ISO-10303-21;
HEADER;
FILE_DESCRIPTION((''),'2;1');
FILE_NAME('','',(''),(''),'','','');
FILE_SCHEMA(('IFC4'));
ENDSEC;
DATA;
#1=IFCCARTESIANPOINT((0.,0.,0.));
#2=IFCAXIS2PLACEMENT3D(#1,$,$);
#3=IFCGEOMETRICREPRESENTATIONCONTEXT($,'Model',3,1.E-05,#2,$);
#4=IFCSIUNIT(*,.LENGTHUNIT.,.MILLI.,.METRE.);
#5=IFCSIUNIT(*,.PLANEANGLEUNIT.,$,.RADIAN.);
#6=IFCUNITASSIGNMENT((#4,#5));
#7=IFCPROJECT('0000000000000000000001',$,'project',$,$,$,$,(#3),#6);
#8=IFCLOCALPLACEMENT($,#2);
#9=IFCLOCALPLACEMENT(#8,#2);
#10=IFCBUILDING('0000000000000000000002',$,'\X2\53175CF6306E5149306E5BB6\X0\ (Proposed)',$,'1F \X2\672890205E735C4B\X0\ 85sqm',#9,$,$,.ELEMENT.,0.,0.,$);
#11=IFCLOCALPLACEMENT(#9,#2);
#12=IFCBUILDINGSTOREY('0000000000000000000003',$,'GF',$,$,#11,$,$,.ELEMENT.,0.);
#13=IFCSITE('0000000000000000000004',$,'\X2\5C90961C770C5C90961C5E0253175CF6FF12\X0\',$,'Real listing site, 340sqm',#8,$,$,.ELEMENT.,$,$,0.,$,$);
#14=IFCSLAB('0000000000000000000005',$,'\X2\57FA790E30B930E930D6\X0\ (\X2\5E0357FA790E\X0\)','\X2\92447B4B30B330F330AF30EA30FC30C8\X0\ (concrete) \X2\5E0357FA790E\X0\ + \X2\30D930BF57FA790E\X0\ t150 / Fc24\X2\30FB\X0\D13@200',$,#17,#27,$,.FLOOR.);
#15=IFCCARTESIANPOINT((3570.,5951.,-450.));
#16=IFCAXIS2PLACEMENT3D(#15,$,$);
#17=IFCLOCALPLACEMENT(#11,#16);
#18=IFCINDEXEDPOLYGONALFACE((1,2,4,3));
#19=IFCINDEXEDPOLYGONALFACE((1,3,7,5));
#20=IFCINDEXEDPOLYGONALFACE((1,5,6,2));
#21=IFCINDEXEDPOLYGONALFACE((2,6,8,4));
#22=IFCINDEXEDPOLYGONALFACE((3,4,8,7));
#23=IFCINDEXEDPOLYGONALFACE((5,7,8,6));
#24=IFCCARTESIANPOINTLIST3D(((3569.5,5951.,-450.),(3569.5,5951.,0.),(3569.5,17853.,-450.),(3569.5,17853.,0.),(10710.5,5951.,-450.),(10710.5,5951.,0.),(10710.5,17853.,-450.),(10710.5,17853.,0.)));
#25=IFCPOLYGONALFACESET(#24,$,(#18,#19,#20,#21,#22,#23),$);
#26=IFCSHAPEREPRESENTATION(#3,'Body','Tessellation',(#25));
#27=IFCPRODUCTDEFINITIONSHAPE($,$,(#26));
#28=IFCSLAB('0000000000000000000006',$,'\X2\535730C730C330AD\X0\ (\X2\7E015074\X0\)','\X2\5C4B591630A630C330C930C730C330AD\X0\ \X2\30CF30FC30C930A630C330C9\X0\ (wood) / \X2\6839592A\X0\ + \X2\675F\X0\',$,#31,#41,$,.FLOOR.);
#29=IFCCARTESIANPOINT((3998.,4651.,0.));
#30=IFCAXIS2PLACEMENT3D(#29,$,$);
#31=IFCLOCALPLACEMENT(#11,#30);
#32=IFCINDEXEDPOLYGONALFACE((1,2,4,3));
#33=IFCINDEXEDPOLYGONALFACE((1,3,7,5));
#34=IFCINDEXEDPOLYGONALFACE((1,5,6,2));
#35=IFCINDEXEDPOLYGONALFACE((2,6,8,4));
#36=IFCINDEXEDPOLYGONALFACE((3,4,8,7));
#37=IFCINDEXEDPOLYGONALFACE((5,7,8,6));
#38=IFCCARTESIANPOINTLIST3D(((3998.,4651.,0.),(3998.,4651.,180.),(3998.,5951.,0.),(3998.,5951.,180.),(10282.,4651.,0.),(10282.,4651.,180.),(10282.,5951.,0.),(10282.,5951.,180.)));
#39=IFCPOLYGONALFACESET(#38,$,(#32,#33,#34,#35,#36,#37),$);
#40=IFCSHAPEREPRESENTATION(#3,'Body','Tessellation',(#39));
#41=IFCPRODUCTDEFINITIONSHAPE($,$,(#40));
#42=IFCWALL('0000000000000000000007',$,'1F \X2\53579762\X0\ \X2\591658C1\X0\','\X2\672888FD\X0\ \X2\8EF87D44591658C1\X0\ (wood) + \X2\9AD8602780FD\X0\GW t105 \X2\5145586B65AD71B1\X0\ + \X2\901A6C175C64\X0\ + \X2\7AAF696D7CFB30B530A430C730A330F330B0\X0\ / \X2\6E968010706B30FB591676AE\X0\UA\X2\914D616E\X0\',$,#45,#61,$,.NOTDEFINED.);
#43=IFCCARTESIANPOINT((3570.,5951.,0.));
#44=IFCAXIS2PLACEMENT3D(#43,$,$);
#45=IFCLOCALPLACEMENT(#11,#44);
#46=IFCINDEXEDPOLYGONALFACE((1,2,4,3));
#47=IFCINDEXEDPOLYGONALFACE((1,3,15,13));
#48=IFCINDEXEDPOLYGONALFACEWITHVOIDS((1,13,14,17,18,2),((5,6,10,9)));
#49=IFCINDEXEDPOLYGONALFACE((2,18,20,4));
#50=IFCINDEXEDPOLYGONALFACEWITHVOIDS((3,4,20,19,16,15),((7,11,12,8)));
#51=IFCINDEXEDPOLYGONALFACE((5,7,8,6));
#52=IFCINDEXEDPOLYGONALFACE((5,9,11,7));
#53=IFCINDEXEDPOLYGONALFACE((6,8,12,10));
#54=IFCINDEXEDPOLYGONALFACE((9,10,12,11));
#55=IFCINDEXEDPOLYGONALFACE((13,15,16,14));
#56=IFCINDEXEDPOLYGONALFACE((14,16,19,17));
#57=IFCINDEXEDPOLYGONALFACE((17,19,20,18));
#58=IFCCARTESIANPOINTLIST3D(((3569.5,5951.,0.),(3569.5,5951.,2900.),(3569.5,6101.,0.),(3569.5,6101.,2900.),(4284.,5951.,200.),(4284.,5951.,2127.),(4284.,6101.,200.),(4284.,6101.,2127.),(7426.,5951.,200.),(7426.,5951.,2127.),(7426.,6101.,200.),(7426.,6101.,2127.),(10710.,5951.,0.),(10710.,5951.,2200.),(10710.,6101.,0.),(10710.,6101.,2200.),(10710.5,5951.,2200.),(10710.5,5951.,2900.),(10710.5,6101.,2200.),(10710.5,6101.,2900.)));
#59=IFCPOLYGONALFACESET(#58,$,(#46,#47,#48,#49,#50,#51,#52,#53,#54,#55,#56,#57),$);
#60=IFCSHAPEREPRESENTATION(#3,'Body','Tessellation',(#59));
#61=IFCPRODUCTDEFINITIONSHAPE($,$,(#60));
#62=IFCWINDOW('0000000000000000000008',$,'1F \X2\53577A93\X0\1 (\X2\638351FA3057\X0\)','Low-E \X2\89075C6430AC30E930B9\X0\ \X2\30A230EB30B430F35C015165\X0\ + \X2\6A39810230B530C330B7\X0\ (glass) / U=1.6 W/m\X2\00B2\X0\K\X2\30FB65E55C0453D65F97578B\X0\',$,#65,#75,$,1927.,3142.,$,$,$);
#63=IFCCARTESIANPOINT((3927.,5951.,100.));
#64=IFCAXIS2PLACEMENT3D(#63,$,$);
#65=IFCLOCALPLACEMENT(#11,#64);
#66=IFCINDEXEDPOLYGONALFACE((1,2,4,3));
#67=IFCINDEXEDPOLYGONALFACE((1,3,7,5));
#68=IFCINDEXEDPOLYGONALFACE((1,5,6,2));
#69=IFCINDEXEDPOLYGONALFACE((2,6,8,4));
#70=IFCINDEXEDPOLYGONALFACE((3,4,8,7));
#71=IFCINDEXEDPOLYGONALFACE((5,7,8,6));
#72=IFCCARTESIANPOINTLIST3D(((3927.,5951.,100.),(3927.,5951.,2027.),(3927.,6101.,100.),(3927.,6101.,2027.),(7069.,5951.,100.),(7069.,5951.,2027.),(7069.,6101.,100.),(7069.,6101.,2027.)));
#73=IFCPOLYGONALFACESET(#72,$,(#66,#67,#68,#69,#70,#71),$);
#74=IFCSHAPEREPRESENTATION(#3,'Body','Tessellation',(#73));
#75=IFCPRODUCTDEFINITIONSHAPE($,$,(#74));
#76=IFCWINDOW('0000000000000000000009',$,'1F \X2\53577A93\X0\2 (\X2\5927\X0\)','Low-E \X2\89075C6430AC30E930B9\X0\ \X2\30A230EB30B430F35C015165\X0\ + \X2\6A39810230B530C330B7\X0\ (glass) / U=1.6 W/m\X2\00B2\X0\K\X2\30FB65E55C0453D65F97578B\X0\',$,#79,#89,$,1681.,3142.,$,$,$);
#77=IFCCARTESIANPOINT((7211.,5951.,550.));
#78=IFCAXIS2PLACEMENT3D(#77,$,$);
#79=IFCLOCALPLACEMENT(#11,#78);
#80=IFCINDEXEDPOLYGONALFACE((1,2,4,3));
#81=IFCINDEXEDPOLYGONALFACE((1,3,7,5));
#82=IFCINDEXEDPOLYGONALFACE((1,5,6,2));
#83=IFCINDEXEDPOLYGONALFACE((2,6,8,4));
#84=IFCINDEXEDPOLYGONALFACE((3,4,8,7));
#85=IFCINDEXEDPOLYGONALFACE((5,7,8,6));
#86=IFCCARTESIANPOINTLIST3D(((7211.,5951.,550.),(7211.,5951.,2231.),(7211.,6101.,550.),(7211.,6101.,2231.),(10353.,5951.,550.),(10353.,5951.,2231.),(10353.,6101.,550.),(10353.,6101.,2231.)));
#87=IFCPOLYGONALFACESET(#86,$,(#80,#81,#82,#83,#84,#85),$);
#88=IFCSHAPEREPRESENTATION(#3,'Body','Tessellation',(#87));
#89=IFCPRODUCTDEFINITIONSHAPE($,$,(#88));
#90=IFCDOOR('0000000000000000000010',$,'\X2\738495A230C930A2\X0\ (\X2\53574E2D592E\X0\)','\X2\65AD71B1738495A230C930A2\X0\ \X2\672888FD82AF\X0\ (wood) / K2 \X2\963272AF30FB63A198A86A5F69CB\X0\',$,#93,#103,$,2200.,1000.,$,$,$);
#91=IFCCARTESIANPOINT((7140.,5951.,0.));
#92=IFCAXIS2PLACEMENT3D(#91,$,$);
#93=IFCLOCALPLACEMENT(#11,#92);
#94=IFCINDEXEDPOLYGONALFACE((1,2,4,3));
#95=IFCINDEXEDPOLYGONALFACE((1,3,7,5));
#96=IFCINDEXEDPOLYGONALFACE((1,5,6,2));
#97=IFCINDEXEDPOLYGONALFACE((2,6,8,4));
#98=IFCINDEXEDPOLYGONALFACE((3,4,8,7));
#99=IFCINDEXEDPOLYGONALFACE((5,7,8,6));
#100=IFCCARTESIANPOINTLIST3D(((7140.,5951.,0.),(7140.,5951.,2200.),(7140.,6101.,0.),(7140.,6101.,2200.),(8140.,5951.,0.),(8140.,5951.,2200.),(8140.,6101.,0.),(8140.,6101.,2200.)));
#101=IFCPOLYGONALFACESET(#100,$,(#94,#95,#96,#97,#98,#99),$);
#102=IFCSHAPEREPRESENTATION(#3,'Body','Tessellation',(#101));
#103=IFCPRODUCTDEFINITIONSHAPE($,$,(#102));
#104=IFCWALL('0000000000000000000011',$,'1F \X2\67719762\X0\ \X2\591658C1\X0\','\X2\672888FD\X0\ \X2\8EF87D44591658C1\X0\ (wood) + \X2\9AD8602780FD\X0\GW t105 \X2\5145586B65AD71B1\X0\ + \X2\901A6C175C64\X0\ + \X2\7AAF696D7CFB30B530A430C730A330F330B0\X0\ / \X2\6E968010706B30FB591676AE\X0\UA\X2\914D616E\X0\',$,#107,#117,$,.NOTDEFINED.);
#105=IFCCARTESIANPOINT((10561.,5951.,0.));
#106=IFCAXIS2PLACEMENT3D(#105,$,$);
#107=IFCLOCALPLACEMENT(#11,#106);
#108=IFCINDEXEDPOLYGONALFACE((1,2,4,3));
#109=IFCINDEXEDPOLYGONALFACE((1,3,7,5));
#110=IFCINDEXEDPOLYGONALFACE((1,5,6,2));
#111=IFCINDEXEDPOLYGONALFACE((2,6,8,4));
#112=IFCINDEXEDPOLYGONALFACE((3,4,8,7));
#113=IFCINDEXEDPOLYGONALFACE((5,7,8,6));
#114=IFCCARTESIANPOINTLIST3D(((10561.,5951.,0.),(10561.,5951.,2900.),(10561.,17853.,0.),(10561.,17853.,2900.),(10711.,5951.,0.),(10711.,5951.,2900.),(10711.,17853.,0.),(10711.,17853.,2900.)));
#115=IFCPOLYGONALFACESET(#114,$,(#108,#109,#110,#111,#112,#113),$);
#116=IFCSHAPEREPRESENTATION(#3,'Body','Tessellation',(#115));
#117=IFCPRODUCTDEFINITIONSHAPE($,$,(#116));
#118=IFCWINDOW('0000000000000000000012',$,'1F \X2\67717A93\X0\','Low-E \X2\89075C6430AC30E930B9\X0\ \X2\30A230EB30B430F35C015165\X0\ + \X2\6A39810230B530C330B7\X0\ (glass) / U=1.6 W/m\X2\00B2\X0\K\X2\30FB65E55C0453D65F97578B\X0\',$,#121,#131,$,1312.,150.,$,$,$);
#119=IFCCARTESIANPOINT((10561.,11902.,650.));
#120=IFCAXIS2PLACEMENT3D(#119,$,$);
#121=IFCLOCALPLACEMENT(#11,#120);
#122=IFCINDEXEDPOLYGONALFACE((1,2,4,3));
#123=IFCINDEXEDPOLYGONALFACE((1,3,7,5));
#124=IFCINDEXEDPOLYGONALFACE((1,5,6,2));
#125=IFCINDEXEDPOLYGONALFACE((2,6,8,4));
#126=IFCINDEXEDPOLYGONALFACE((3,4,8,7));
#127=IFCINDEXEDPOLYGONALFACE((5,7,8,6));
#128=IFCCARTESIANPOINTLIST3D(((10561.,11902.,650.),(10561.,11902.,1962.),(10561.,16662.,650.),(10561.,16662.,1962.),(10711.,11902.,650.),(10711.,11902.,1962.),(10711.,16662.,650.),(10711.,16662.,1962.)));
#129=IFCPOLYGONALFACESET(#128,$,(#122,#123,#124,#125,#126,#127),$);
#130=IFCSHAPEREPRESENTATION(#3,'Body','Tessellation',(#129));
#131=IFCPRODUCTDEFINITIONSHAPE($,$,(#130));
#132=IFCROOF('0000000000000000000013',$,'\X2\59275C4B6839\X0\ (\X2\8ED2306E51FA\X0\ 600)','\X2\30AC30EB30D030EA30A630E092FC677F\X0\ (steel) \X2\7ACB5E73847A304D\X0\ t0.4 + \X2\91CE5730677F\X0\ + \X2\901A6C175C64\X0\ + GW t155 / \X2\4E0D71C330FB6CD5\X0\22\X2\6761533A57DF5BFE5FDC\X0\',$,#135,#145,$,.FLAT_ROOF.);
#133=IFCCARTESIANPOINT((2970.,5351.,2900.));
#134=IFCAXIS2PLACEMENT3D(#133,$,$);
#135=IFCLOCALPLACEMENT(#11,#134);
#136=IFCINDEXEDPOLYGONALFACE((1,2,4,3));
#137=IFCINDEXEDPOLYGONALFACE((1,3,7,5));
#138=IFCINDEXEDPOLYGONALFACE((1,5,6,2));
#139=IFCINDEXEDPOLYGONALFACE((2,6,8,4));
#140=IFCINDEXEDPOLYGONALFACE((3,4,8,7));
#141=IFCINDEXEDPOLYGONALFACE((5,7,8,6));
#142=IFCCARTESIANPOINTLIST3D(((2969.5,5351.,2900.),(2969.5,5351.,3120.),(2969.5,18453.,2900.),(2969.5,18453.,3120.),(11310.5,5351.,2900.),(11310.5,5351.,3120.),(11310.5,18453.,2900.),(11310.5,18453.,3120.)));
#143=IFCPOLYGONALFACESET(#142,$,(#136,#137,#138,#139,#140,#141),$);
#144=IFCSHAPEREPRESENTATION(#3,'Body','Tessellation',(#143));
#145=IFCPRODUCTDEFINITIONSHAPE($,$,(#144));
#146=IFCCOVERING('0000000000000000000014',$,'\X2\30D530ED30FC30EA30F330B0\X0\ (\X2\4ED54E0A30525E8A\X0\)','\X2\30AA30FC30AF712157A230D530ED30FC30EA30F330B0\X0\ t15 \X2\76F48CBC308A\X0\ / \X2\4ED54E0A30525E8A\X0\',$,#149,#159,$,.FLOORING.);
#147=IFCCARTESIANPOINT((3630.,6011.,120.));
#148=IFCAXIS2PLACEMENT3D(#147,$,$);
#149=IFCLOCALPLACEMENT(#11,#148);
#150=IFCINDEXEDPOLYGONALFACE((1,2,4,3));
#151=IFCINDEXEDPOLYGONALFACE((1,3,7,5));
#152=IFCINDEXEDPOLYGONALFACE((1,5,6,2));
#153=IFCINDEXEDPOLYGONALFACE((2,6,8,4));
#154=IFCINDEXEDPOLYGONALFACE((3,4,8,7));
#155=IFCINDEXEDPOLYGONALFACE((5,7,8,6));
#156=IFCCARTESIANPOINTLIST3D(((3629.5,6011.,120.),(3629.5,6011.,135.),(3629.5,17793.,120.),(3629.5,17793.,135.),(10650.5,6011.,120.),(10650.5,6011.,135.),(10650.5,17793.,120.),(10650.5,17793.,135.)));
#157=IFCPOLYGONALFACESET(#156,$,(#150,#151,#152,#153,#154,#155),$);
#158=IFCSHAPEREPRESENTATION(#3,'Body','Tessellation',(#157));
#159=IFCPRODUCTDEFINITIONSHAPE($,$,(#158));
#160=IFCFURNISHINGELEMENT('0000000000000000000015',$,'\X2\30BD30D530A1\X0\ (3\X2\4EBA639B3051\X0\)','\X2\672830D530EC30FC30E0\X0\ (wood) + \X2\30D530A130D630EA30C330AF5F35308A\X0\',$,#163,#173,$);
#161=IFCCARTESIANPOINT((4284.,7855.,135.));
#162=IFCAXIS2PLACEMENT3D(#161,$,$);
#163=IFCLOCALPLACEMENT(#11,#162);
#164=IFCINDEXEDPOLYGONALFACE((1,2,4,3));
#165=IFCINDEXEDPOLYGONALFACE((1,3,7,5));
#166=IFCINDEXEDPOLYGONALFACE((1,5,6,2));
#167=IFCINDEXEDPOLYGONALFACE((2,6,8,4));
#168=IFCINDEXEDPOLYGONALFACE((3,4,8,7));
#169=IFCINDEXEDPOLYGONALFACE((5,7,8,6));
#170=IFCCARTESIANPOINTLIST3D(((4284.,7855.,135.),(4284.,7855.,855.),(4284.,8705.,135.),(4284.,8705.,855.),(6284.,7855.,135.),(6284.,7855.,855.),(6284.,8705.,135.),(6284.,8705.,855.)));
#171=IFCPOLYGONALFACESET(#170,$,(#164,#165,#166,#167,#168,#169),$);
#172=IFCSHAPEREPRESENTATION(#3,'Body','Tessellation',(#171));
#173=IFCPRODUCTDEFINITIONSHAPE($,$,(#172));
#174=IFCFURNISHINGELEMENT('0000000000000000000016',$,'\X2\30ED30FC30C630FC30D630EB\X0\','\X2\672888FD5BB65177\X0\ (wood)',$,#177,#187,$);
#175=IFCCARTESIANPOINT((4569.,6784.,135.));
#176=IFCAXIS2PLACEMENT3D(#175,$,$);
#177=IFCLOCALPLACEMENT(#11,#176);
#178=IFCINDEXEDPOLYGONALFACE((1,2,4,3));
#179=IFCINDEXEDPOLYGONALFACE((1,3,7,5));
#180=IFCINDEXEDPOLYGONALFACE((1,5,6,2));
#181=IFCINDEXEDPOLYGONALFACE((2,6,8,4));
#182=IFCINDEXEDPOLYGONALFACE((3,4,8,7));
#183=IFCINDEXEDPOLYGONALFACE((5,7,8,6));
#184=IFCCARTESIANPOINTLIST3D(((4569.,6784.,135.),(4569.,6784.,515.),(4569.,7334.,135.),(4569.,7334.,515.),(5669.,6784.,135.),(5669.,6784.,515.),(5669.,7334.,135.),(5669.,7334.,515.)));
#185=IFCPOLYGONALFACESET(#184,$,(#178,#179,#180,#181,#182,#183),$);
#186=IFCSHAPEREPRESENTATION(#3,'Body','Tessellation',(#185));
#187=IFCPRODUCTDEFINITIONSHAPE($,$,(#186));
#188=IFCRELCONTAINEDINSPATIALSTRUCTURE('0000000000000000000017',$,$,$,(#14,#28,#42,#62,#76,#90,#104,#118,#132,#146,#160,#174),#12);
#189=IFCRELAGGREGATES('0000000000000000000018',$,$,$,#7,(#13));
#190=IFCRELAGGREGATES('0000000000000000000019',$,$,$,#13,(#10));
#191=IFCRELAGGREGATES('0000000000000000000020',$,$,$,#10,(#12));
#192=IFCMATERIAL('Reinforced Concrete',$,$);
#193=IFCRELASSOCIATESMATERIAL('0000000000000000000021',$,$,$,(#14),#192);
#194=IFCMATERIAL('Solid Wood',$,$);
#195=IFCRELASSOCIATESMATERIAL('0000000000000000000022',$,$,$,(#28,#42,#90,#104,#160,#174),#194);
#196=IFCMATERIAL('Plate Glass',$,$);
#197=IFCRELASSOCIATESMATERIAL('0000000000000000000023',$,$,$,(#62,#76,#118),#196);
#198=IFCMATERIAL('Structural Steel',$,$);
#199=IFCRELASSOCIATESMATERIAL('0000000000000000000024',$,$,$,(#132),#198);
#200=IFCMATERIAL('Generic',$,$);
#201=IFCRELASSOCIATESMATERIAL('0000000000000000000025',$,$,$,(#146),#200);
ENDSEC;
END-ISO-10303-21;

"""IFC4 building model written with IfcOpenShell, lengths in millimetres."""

from ifc_helpers import new_model, si_unit, frame, frame_2d, origin, place, context, project, spatial, rectangle, extrude, material, element, fill, save


model = new_model("IFC4")

# Units and contexts
model_context = context("Model", 3, precision=1e-05, world=origin())
ifc_project = project(units=[si_unit("LENGTHUNIT", "METRE", prefix="MILLI"), si_unit("PLANEANGLEUNIT", "RADIAN")], contexts=[model_context])

# Site, building, storey
site_placement = place(None, origin())
site = spatial("IfcSite", under=ifc_project, at=site_placement, Name="岐阜県岐阜市北島２", ObjectType="Real listing site, 340sqm", CompositionType="ELEMENT", RefElevation=0.0)
building_placement = place(site_placement, origin())
building = spatial("IfcBuilding", under=site, at=building_placement, Name="北島の光の家 (Proposed)", ObjectType="1F 木造平屋 85sqm", CompositionType="ELEMENT", ElevationOfRefHeight=0.0, ElevationOfTerrain=0.0)
storey_placement = place(building_placement, origin())
storey = spatial("IfcBuildingStorey", under=building, at=storey_placement, Name="GF", CompositionType="ELEMENT", Elevation=0.0)

# Slabs
ifc_material_1 = material(Name="Reinforced Concrete")
slab_1_placement = place(storey_placement, frame((3570.0, 5951.0, -450.0)))
element("IfcSlab", 1, at=slab_1_placement, inside=storey, material=ifc_material_1, Name="基礎スラブ (布基礎)", Description="鉄筋コンクリート (concrete) 布基礎 + ベタ基礎 t150 / Fc24・D13@200", PredefinedType="FLOOR", context=model_context, shape_type="SweptSolid", body=[
    extrude(rectangle(XDim=7141.0, YDim=11902.0, at=frame_2d((3570.0, 5951.0))), frame((3570.0, 5951.0, -450.0)), (0.0, 0.0, 1.0), 450.0),
])
ifc_material_2 = material(Name="Solid Wood")
slab_2_placement = place(storey_placement, frame((3998.0, 4651.0, 0.0)))
element("IfcSlab", 2, at=slab_2_placement, inside=storey, material=ifc_material_2, Name="南デッキ (縁側)", Description="屋外ウッドデッキ ハードウッド (wood) / 根太 + 束", PredefinedType="FLOOR", context=model_context, shape_type="SweptSolid", body=[
    extrude(rectangle(XDim=6284.0, YDim=1300.0, at=frame_2d((3142.0, 650.0))), frame((3998.0, 4651.0, 0.0)), (0.0, 0.0, 1.0), 180.0),
])

# Wall, openings, windows, door
wall_1_placement = place(storey_placement, frame((3570.0, 5951.0, 0.0)))
wall_1 = element("IfcWall", 3, at=wall_1_placement, inside=storey, material=ifc_material_2, Name="1F 南面 外壁", Description="木製 軸組外壁 (wood) + 高性能GW t105 充填断熱 + 通気層 + 窯業系サイディング / 準耐火・外皮UA配慮", PredefinedType="NOTDEFINED", context=model_context, shape_type="SweptSolid", body=[
    extrude(rectangle(XDim=7141.0, YDim=150.0, at=frame_2d((3570.0, 75.0))), frame((3570.0, 5951.0, 0.0)), (0.0, 0.0, 1.0), 2900.0),
])
opening_1_placement = place(storey_placement, frame((3927.0, 5951.0, 100.0)))
opening_1 = element("IfcOpeningElement", 4, at=opening_1_placement, cuts=wall_1, PredefinedType="NOTDEFINED", context=model_context, shape_type="SweptSolid", body=[
    extrude(rectangle(XDim=3142.0, YDim=150.0, at=frame_2d((1571.0, 75.0))), frame((3927.0, 5951.0, 100.0)), (0.0, 0.0, 1.0), 1927.0),
])
opening_2_placement = place(storey_placement, frame((7211.0, 5951.0, 550.0)))
opening_2 = element("IfcOpeningElement", 5, at=opening_2_placement, cuts=wall_1, PredefinedType="NOTDEFINED", context=model_context, shape_type="SweptSolid", body=[
    extrude(rectangle(XDim=3142.0, YDim=150.0, at=frame_2d((1571.0, 75.0))), frame((7211.0, 5951.0, 550.0)), (0.0, 0.0, 1.0), 1681.0),
])
opening_3_placement = place(storey_placement, frame((7140.0, 5951.0, 0.0)))
opening_3 = element("IfcOpeningElement", 6, at=opening_3_placement, cuts=wall_1, PredefinedType="NOTDEFINED", context=model_context, shape_type="SweptSolid", body=[
    extrude(rectangle(XDim=1000.0, YDim=150.0, at=frame_2d((500.0, 75.0))), frame((7140.0, 5951.0, 0.0)), (0.0, 0.0, 1.0), 2200.0),
])
ifc_material_3 = material(Name="Plate Glass")
window_1_placement = place(storey_placement, frame((3927.0, 5951.0, 100.0)))
window_1 = element("IfcWindow", 7, at=window_1_placement, inside=storey, material=ifc_material_3, Name="1F 南窓1 (掃出し)", Description="Low-E 複層ガラス アルゴン封入 + 樹脂サッシ (glass) / U=1.6 W/m²K・日射取得型", OverallHeight=1927.0, OverallWidth=3142.0, context=model_context, shape_type="SweptSolid", body=[
    extrude(rectangle(XDim=3142.0, YDim=150.0, at=frame_2d((1571.0, 75.0))), frame((3927.0, 5951.0, 100.0)), (0.0, 0.0, 1.0), 1927.0),
])
fill(opening_1, window_1)
window_2_placement = place(storey_placement, frame((7211.0, 5951.0, 550.0)))
window_2 = element("IfcWindow", 8, at=window_2_placement, inside=storey, material=ifc_material_3, Name="1F 南窓2 (大)", Description="Low-E 複層ガラス アルゴン封入 + 樹脂サッシ (glass) / U=1.6 W/m²K・日射取得型", OverallHeight=1681.0, OverallWidth=3142.0, context=model_context, shape_type="SweptSolid", body=[
    extrude(rectangle(XDim=3142.0, YDim=150.0, at=frame_2d((1571.0, 75.0))), frame((7211.0, 5951.0, 550.0)), (0.0, 0.0, 1.0), 1681.0),
])
fill(opening_2, window_2)
door_placement = place(storey_placement, frame((7140.0, 5951.0, 0.0)))
door = element("IfcDoor", 9, at=door_placement, inside=storey, material=ifc_material_2, Name="玄関ドア (南中央)", Description="断熱玄関ドア 木製芯 (wood) / K2 防犯・採風機構", OverallHeight=2200.0, OverallWidth=1000.0, context=model_context, shape_type="SweptSolid", body=[
    extrude(rectangle(XDim=1000.0, YDim=150.0, at=frame_2d((500.0, 75.0))), frame((7140.0, 5951.0, 0.0)), (0.0, 0.0, 1.0), 2200.0),
])
fill(opening_3, door)

# Wall, opening, window
wall_2_placement = place(storey_placement, frame((10561.0, 5951.0, 0.0)))
wall_2 = element("IfcWall", 10, at=wall_2_placement, inside=storey, material=ifc_material_2, Name="1F 東面 外壁", Description="木製 軸組外壁 (wood) + 高性能GW t105 充填断熱 + 通気層 + 窯業系サイディング / 準耐火・外皮UA配慮", PredefinedType="NOTDEFINED", context=model_context, shape_type="SweptSolid", body=[
    extrude(rectangle(XDim=150.0, YDim=11902.0, at=frame_2d((75.0, 5951.0))), frame((10561.0, 5951.0, 0.0)), (0.0, 0.0, 1.0), 2900.0),
])
opening_4_placement = place(storey_placement, frame((10561.0, 11902.0, 650.0)))
opening_4 = element("IfcOpeningElement", 11, at=opening_4_placement, cuts=wall_2, PredefinedType="NOTDEFINED", context=model_context, shape_type="SweptSolid", body=[
    extrude(rectangle(XDim=150.0, YDim=4760.0, at=frame_2d((75.0, 2380.0))), frame((10561.0, 11902.0, 650.0)), (0.0, 0.0, 1.0), 1312.0),
])
window_3_placement = place(storey_placement, frame((10561.0, 11902.0, 650.0)))
window_3 = element("IfcWindow", 12, at=window_3_placement, inside=storey, material=ifc_material_3, Name="1F 東窓", Description="Low-E 複層ガラス アルゴン封入 + 樹脂サッシ (glass) / U=1.6 W/m²K・日射取得型", OverallHeight=1312.0, OverallWidth=150.0, context=model_context, shape_type="SweptSolid", body=[
    extrude(rectangle(XDim=150.0, YDim=4760.0, at=frame_2d((75.0, 2380.0))), frame((10561.0, 11902.0, 650.0)), (0.0, 0.0, 1.0), 1312.0),
])
fill(opening_4, window_3)

# Roof
ifc_material_4 = material(Name="Structural Steel")
roof_placement = place(storey_placement, frame((2970.0, 5351.0, 2900.0)))
element("IfcRoof", 13, at=roof_placement, inside=storey, material=ifc_material_4, Name="大屋根 (軒の出 600)", Description="ガルバリウム鋼板 (steel) 立平葺き t0.4 + 野地板 + 通気層 + GW t155 / 不燃・法22条区域対応", PredefinedType="FLAT_ROOF", context=model_context, shape_type="SweptSolid", body=[
    extrude(rectangle(XDim=8341.0, YDim=13102.0, at=frame_2d((4170.0, 6551.0))), frame((2970.0, 5351.0, 2900.0)), (0.0, 0.0, 1.0), 220.0),
])

# Covering
ifc_material_5 = material(Name="Generic")
covering_placement = place(storey_placement, frame((3630.0, 6011.0, 120.0)))
element("IfcCovering", 14, at=covering_placement, inside=storey, material=ifc_material_5, Name="フローリング (仕上げ床)", Description="オーク無垢フローリング t15 直貼り / 仕上げ床", PredefinedType="FLOORING", context=model_context, shape_type="SweptSolid", body=[
    extrude(rectangle(XDim=7021.0, YDim=11782.0, at=frame_2d((3510.0, 5891.0))), frame((3630.0, 6011.0, 120.0)), (0.0, 0.0, 1.0), 15.0),
])

# Furnishing elements
furnishing_1_placement = place(storey_placement, frame((4284.0, 7855.0, 135.0)))
element("IfcFurnishingElement", 15, at=furnishing_1_placement, inside=storey, material=ifc_material_2, Name="ソファ (3人掛け)", Description="木フレーム (wood) + ファブリック張り", context=model_context, shape_type="SweptSolid", body=[
    extrude(rectangle(XDim=2000.0, YDim=850.0, at=frame_2d((1000.0, 425.0))), frame((4284.0, 7855.0, 135.0)), (0.0, 0.0, 1.0), 720.0),
])
furnishing_2_placement = place(storey_placement, frame((4569.0, 6784.0, 135.0)))
element("IfcFurnishingElement", 16, at=furnishing_2_placement, inside=storey, material=ifc_material_2, Name="ローテーブル", Description="木製家具 (wood)", context=model_context, shape_type="SweptSolid", body=[
    extrude(rectangle(XDim=1100.0, YDim=550.0, at=frame_2d((550.0, 275.0))), frame((4569.0, 6784.0, 135.0)), (0.0, 0.0, 1.0), 380.0),
])

save(model, "model.ifc")
